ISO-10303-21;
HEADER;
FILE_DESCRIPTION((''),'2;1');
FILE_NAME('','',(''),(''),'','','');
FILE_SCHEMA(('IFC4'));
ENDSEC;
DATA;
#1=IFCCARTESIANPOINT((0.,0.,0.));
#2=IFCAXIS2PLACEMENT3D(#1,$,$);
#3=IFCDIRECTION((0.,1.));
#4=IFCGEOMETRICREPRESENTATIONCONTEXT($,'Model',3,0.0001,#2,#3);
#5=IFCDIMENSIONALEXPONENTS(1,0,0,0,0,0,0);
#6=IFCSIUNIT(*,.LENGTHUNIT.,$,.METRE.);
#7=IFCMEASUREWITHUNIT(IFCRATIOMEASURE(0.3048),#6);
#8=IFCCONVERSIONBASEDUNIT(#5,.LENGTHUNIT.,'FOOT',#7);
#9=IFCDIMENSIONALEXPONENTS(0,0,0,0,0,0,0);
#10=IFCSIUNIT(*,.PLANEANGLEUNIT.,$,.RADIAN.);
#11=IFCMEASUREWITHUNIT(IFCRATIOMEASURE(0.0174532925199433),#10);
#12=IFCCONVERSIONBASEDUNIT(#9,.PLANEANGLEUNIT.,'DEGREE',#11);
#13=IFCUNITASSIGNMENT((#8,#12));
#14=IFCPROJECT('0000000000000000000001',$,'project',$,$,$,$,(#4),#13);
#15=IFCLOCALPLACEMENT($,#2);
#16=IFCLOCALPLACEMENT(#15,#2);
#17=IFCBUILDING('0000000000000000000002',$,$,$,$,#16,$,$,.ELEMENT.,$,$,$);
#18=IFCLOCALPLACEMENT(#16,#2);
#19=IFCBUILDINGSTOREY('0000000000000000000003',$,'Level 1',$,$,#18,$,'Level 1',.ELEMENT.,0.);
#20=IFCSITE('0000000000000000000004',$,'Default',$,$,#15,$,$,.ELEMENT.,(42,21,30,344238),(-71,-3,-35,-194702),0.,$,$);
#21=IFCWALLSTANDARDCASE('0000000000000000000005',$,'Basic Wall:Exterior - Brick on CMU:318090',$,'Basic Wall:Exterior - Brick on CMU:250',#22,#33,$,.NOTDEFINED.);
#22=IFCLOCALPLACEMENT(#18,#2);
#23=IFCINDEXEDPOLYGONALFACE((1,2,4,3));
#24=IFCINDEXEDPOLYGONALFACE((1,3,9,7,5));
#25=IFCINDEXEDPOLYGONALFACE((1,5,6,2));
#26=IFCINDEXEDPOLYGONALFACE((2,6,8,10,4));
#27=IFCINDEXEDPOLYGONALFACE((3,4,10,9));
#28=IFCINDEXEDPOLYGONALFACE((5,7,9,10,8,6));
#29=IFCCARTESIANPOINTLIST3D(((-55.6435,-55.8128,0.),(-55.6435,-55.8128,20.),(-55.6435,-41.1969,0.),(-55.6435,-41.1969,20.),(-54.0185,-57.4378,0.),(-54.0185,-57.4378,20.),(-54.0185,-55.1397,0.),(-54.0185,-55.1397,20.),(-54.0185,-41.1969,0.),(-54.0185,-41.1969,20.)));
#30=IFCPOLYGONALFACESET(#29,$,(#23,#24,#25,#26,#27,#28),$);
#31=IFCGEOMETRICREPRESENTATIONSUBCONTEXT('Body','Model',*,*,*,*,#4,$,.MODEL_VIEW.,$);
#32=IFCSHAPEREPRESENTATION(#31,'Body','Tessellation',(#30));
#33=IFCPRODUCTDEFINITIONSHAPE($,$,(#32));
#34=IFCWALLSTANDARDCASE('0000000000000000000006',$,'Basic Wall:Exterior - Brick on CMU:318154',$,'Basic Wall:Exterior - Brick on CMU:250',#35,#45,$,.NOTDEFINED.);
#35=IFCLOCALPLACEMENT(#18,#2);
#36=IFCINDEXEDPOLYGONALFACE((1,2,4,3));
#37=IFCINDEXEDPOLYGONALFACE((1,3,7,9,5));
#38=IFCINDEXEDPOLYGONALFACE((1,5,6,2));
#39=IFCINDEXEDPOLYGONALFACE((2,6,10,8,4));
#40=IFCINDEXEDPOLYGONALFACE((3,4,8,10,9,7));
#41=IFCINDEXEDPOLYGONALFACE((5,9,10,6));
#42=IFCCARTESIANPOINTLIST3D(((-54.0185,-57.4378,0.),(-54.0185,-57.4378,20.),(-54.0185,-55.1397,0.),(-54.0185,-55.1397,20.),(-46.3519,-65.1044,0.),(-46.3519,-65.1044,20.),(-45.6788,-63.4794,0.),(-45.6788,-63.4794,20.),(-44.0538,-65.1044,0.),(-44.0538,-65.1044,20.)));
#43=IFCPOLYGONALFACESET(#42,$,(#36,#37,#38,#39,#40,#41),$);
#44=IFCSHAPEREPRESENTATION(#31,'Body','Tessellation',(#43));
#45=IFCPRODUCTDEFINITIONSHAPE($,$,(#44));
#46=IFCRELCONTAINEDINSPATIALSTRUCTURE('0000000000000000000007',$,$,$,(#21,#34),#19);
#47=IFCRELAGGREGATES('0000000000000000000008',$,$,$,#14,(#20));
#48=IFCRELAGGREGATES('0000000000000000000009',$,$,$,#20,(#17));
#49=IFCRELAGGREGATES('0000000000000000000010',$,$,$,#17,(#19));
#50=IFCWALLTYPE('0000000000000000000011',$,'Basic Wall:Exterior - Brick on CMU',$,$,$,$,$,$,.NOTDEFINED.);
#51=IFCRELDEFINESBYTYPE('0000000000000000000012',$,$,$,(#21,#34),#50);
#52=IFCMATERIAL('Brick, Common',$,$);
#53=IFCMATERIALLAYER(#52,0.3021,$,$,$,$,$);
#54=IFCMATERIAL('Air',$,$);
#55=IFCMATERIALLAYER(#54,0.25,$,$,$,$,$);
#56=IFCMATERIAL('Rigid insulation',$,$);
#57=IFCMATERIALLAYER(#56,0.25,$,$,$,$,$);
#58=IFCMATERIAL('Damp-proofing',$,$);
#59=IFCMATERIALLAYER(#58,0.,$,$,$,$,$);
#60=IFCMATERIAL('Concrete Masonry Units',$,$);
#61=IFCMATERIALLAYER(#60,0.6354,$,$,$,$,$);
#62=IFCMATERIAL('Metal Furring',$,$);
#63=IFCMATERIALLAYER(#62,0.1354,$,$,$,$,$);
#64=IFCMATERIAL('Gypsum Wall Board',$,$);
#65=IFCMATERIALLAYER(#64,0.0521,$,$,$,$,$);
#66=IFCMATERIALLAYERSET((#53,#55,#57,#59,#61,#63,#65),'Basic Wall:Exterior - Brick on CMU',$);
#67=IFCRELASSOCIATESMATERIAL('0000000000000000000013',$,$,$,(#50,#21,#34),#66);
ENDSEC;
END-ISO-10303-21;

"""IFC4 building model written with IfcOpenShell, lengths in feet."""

from ifc_helpers import new_model, entity, si_unit, converted_unit, direction, frame, origin, place, context, subcontext, project, spatial, polyline, outline, extrude, material, layer, layer_set, layer_usage, type_object, element, save


model = new_model("IFC4")

# Units and contexts
model_context = context("Model", 3, precision=0.0001, world=origin(), true_north=direction((0.0, 1.0)))
body_context = subcontext(model_context, "Body", "Model", "MODEL_VIEW")
ifc_project = project(units=[converted_unit("LENGTHUNIT", "FOOT", entity("IfcRatioMeasure", 0.3048), si_unit("LENGTHUNIT", "METRE"), dimensions=[1, 0, 0, 0, 0, 0, 0]), converted_unit("PLANEANGLEUNIT", "DEGREE", entity("IfcRatioMeasure", 0.0174532925199433), si_unit("PLANEANGLEUNIT", "RADIAN"), dimensions=[0, 0, 0, 0, 0, 0, 0])], contexts=[model_context])

# Site, building, storey
site_placement = place(None, origin())
site = spatial("IfcSite", under=ifc_project, at=site_placement, Name="Default", CompositionType="ELEMENT", RefLatitude=(42, 21, 30, 344238), RefLongitude=(-71, -3, -35, -194702), RefElevation=0.0)
building_placement = place(site_placement, origin())
building = spatial("IfcBuilding", under=site, at=building_placement, CompositionType="ELEMENT")
storey_placement = place(building_placement, origin())
storey = spatial("IfcBuildingStorey", under=building, at=storey_placement, Name="Level 1", LongName="Level 1", CompositionType="ELEMENT", Elevation=0.0)

# Walls
ifc_material_1 = material(Name="Brick, Common")
ifc_layer_1 = layer(ifc_material_1, 0.3021)
ifc_material_2 = material(Name="Air")
ifc_layer_2 = layer(ifc_material_2, 0.25)
ifc_material_3 = material(Name="Rigid insulation")
ifc_layer_3 = layer(ifc_material_3, 0.25)
ifc_material_4 = material(Name="Damp-proofing")
ifc_layer_4 = layer(ifc_material_4, 0.0)
ifc_material_5 = material(Name="Concrete Masonry Units")
ifc_layer_5 = layer(ifc_material_5, 0.6354)
ifc_material_6 = material(Name="Metal Furring")
ifc_layer_6 = layer(ifc_material_6, 0.1354)
ifc_material_7 = material(Name="Gypsum Wall Board")
ifc_layer_7 = layer(ifc_material_7, 0.0521)
ifc_layer_set = layer_set([ifc_layer_1, ifc_layer_2, ifc_layer_3, ifc_layer_4, ifc_layer_5, ifc_layer_6, ifc_layer_7], Name="Basic Wall:Exterior - Brick on CMU")
ifc_layer_usage_1 = layer_usage(ifc_layer_set, "AXIS2", "NEGATIVE", 0.8125)
wall_type = type_object("IfcWallType", Name="Basic Wall:Exterior - Brick on CMU", PredefinedType="NOTDEFINED", material=ifc_layer_set)
wall_1_placement = place(storey_placement, frame((-54.831, -41.1969, 0.0), z_axis=(0.0, 0.0, 1.0), x_axis=(0.0, -1.0, 0.0)))
element("IfcWallStandardCase", 1, at=wall_1_placement, inside=storey, type_object=wall_type, material=ifc_layer_usage_1, Name="Basic Wall:Exterior - Brick on CMU:318090", ObjectType="Basic Wall:Exterior - Brick on CMU:250", PredefinedType="NOTDEFINED", context=body_context, shape_type="SweptSolid", body=[
    extrude(outline(polyline([(14.6159, -0.8125), (16.2409, 0.8125), (13.9428, 0.8125), (0.0, 0.8125), (0.0, -0.8125), (14.6159, -0.8125)])), origin(), (0.0, 0.0, 1.0), 20.0),
])
ifc_layer_usage_2 = layer_usage(ifc_layer_set, "AXIS2", "NEGATIVE", 0.8125)
wall_2_placement = place(storey_placement, frame((-54.593, -55.7142, 0.0), z_axis=(0.0, 0.0, 1.0), x_axis=(0.707107, -0.707107, 0.0)))
element("IfcWallStandardCase", 2, at=wall_2_placement, inside=storey, type_object=wall_type, material=ifc_layer_usage_2, Name="Basic Wall:Exterior - Brick on CMU:318154", ObjectType="Basic Wall:Exterior - Brick on CMU:250", PredefinedType="NOTDEFINED", context=body_context, shape_type="SweptSolid", body=[
    extrude(outline(polyline([(12.4672, -0.8125), (14.0922, 0.8125), (11.7941, 0.8125), (0.0, 0.8125), (1.625, -0.8125), (12.4672, -0.8125)])), origin(), (0.0, 0.0, 1.0), 20.0),
])

save(model, "model.ifc")
